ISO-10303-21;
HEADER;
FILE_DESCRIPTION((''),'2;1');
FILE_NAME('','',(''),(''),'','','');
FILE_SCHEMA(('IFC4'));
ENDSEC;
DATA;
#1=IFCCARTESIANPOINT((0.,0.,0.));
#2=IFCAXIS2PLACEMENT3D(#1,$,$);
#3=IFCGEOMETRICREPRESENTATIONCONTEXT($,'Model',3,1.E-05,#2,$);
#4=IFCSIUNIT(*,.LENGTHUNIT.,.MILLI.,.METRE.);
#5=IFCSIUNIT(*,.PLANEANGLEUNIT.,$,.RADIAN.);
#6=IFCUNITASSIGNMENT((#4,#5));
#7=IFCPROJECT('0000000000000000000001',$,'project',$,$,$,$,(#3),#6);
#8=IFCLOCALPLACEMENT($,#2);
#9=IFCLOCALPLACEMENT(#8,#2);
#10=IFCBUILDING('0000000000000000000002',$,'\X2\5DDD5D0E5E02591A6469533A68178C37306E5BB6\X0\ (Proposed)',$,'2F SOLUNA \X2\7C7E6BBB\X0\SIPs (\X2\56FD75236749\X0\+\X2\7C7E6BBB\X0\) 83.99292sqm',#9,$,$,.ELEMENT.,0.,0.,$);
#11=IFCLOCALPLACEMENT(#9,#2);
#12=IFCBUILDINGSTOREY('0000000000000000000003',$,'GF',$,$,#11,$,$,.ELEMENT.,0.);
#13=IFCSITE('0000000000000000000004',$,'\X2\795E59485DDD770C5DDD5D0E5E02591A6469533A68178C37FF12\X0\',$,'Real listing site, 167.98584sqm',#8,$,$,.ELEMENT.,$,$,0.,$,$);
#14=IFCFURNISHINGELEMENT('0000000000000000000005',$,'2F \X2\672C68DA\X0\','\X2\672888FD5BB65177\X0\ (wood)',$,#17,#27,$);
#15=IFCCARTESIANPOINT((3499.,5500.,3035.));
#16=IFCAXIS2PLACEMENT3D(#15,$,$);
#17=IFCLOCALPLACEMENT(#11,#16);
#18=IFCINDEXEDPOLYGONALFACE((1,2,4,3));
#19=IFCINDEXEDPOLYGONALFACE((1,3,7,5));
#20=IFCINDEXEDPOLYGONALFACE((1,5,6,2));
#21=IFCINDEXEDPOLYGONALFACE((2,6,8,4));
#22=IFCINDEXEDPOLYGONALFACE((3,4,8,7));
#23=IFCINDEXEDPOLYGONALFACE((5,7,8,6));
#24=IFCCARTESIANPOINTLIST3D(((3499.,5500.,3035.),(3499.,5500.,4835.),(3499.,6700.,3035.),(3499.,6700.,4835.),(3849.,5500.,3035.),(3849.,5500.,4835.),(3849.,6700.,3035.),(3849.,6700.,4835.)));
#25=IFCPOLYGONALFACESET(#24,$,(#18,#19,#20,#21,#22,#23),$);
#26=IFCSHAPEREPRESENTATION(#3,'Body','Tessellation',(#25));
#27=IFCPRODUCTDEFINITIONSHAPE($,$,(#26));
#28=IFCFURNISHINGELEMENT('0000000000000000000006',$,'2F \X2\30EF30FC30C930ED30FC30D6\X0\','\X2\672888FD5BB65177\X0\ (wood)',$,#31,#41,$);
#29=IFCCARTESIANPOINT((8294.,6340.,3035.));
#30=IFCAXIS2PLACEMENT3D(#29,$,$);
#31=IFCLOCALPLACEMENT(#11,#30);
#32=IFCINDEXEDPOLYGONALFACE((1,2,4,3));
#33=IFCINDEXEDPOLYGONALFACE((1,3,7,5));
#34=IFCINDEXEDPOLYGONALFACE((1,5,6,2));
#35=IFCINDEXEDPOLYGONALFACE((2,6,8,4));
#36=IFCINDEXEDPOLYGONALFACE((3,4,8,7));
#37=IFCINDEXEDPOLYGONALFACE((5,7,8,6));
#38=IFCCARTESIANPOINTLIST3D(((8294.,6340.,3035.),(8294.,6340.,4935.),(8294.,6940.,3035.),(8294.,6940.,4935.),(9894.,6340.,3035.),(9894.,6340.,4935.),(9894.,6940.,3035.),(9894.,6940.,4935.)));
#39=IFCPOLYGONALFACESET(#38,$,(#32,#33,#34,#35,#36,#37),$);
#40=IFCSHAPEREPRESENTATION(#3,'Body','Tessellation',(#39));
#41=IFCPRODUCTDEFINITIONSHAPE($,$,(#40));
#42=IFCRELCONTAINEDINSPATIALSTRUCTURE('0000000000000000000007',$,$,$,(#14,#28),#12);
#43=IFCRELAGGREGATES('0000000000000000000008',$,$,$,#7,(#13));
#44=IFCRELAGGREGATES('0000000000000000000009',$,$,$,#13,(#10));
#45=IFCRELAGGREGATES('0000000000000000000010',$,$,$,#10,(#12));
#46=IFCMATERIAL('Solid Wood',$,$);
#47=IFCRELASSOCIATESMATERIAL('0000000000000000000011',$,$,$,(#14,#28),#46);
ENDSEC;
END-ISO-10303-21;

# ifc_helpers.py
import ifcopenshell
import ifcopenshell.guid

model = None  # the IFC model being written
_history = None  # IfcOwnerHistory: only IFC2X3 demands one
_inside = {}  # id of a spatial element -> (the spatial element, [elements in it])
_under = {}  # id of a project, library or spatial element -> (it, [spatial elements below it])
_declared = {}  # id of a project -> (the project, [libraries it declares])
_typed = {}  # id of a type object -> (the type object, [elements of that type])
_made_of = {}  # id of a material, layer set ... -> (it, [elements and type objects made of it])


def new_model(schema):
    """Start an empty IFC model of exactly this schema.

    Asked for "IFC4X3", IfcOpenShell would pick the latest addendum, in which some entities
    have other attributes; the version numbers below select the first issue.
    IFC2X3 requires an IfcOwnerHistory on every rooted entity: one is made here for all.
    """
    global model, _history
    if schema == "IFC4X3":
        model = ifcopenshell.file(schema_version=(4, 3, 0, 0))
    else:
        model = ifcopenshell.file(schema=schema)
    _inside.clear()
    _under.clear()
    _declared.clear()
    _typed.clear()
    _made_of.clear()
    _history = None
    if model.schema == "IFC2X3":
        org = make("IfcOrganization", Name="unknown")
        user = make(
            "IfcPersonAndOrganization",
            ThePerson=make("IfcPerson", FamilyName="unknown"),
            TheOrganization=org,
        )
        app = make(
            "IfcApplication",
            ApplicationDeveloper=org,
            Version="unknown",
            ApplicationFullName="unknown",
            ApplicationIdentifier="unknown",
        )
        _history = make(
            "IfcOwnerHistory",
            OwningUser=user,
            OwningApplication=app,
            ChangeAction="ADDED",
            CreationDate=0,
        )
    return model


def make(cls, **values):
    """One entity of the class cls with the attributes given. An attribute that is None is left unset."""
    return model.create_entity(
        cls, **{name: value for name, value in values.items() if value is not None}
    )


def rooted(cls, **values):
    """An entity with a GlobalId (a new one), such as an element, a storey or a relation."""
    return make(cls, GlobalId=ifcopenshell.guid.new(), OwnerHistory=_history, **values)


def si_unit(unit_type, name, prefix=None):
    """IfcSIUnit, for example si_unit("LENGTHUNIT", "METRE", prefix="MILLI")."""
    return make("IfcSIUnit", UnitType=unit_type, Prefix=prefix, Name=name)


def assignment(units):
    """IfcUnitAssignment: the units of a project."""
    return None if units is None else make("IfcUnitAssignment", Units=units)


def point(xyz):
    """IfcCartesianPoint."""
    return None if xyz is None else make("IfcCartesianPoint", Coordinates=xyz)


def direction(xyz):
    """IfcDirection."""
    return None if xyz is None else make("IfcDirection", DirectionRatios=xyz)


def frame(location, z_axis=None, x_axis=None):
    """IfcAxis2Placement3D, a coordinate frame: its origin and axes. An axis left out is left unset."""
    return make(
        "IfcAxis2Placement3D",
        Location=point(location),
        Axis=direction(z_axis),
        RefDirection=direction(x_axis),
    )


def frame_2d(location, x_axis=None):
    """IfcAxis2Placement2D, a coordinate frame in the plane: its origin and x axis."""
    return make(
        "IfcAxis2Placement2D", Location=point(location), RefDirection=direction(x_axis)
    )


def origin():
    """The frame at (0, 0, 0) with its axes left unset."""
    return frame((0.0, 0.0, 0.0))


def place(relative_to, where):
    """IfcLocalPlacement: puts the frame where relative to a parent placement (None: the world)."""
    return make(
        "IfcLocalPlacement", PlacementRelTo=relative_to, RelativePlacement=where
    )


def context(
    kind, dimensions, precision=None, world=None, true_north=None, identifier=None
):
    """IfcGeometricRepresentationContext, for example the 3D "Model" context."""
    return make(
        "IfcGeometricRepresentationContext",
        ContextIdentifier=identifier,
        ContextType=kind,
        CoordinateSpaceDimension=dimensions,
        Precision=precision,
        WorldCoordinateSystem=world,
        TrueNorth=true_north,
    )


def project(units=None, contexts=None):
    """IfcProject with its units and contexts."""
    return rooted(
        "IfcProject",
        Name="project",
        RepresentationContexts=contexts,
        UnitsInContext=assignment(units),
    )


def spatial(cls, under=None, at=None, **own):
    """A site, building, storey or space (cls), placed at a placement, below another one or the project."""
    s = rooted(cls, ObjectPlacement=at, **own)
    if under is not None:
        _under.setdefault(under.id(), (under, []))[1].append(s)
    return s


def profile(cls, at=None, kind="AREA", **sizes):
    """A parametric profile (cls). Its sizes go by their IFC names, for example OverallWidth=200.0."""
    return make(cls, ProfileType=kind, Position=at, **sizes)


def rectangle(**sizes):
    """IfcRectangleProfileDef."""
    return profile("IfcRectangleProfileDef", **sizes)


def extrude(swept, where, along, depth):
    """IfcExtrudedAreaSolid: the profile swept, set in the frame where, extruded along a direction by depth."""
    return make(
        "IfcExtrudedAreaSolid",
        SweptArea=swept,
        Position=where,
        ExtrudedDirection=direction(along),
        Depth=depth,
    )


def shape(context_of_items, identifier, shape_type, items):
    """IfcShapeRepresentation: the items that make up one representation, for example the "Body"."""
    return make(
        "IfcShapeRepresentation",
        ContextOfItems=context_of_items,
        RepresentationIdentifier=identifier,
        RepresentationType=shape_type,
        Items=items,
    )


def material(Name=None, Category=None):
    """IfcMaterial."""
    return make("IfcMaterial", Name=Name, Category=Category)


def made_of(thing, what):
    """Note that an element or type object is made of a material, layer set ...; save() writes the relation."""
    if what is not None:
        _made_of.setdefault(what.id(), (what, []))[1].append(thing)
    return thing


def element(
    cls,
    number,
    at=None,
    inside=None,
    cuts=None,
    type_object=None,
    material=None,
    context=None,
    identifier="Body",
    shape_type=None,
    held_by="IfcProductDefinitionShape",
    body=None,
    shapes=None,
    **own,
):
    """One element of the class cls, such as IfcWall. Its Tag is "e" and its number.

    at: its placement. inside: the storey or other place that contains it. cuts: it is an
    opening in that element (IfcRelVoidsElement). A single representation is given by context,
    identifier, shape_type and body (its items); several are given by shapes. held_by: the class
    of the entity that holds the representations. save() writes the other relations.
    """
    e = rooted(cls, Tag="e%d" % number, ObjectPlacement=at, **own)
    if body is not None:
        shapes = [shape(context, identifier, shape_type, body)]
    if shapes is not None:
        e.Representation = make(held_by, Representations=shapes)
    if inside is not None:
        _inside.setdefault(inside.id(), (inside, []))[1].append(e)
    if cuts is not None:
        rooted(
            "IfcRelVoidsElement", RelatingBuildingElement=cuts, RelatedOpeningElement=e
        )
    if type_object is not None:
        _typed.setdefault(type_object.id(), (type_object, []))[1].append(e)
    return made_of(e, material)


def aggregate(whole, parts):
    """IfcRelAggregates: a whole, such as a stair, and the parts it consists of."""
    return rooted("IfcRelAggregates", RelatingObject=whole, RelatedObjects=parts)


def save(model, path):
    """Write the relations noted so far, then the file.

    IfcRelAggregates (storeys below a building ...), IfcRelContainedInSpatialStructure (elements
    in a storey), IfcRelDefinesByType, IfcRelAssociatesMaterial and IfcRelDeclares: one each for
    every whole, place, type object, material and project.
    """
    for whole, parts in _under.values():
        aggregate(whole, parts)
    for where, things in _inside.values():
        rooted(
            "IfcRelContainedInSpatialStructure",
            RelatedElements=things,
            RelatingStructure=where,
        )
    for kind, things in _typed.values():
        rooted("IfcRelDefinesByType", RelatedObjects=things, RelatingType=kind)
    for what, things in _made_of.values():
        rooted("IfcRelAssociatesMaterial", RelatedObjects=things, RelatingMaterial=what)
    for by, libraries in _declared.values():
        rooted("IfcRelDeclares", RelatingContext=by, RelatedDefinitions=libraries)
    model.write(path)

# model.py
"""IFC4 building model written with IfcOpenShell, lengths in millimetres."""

from ifc_helpers import new_model, si_unit, frame, frame_2d, origin, place, context, project, spatial, rectangle, extrude, material, element, save


model = new_model("IFC4")

# Units and contexts
model_context = context("Model", 3, precision=1e-05, world=origin())
ifc_project = project(units=[si_unit("LENGTHUNIT", "METRE", prefix="MILLI"), si_unit("PLANEANGLEUNIT", "RADIAN")], contexts=[model_context])

# Site, building, storey
site_placement = place(None, origin())
site = spatial("IfcSite", under=ifc_project, at=site_placement, Name="神奈川県川崎市多摩区栗谷２", ObjectType="Real listing site, 167.98584sqm", CompositionType="ELEMENT", RefElevation=0.0)
building_placement = place(site_placement, origin())
building = spatial("IfcBuilding", under=site, at=building_placement, Name="川崎市多摩区栗谷の家 (Proposed)", ObjectType="2F SOLUNA 籾殻SIPs (国産杉+籾殻) 83.99292sqm", CompositionType="ELEMENT", ElevationOfRefHeight=0.0, ElevationOfTerrain=0.0)
storey_placement = place(building_placement, origin())
storey = spatial("IfcBuildingStorey", under=building, at=storey_placement, Name="GF", CompositionType="ELEMENT", Elevation=0.0)

# Shared definitions
ifc_material_1 = material(Name="Solid Wood")

# Furnishing elements
furnishing_1_placement = place(storey_placement, frame((3499.0, 5500.0, 3035.0)))
element("IfcFurnishingElement", 1, at=furnishing_1_placement, inside=storey, material=ifc_material_1, Name="2F 本棚", Description="木製家具 (wood)", context=model_context, shape_type="SweptSolid", body=[
    extrude(rectangle(XDim=350.0, YDim=1200.0, at=frame_2d((175.0, 600.0))), frame((3499.0, 5500.0, 3035.0)), (0.0, 0.0, 1.0), 1800.0),
])
furnishing_2_placement = place(storey_placement, frame((8294.0, 6340.0, 3035.0)))
element("IfcFurnishingElement", 2, at=furnishing_2_placement, inside=storey, material=ifc_material_1, Name="2F ワードローブ", Description="木製家具 (wood)", context=model_context, shape_type="SweptSolid", body=[
    extrude(rectangle(XDim=1600.0, YDim=600.0, at=frame_2d((800.0, 300.0))), frame((8294.0, 6340.0, 3035.0)), (0.0, 0.0, 1.0), 1900.0),
])

save(model, "model.ifc")
